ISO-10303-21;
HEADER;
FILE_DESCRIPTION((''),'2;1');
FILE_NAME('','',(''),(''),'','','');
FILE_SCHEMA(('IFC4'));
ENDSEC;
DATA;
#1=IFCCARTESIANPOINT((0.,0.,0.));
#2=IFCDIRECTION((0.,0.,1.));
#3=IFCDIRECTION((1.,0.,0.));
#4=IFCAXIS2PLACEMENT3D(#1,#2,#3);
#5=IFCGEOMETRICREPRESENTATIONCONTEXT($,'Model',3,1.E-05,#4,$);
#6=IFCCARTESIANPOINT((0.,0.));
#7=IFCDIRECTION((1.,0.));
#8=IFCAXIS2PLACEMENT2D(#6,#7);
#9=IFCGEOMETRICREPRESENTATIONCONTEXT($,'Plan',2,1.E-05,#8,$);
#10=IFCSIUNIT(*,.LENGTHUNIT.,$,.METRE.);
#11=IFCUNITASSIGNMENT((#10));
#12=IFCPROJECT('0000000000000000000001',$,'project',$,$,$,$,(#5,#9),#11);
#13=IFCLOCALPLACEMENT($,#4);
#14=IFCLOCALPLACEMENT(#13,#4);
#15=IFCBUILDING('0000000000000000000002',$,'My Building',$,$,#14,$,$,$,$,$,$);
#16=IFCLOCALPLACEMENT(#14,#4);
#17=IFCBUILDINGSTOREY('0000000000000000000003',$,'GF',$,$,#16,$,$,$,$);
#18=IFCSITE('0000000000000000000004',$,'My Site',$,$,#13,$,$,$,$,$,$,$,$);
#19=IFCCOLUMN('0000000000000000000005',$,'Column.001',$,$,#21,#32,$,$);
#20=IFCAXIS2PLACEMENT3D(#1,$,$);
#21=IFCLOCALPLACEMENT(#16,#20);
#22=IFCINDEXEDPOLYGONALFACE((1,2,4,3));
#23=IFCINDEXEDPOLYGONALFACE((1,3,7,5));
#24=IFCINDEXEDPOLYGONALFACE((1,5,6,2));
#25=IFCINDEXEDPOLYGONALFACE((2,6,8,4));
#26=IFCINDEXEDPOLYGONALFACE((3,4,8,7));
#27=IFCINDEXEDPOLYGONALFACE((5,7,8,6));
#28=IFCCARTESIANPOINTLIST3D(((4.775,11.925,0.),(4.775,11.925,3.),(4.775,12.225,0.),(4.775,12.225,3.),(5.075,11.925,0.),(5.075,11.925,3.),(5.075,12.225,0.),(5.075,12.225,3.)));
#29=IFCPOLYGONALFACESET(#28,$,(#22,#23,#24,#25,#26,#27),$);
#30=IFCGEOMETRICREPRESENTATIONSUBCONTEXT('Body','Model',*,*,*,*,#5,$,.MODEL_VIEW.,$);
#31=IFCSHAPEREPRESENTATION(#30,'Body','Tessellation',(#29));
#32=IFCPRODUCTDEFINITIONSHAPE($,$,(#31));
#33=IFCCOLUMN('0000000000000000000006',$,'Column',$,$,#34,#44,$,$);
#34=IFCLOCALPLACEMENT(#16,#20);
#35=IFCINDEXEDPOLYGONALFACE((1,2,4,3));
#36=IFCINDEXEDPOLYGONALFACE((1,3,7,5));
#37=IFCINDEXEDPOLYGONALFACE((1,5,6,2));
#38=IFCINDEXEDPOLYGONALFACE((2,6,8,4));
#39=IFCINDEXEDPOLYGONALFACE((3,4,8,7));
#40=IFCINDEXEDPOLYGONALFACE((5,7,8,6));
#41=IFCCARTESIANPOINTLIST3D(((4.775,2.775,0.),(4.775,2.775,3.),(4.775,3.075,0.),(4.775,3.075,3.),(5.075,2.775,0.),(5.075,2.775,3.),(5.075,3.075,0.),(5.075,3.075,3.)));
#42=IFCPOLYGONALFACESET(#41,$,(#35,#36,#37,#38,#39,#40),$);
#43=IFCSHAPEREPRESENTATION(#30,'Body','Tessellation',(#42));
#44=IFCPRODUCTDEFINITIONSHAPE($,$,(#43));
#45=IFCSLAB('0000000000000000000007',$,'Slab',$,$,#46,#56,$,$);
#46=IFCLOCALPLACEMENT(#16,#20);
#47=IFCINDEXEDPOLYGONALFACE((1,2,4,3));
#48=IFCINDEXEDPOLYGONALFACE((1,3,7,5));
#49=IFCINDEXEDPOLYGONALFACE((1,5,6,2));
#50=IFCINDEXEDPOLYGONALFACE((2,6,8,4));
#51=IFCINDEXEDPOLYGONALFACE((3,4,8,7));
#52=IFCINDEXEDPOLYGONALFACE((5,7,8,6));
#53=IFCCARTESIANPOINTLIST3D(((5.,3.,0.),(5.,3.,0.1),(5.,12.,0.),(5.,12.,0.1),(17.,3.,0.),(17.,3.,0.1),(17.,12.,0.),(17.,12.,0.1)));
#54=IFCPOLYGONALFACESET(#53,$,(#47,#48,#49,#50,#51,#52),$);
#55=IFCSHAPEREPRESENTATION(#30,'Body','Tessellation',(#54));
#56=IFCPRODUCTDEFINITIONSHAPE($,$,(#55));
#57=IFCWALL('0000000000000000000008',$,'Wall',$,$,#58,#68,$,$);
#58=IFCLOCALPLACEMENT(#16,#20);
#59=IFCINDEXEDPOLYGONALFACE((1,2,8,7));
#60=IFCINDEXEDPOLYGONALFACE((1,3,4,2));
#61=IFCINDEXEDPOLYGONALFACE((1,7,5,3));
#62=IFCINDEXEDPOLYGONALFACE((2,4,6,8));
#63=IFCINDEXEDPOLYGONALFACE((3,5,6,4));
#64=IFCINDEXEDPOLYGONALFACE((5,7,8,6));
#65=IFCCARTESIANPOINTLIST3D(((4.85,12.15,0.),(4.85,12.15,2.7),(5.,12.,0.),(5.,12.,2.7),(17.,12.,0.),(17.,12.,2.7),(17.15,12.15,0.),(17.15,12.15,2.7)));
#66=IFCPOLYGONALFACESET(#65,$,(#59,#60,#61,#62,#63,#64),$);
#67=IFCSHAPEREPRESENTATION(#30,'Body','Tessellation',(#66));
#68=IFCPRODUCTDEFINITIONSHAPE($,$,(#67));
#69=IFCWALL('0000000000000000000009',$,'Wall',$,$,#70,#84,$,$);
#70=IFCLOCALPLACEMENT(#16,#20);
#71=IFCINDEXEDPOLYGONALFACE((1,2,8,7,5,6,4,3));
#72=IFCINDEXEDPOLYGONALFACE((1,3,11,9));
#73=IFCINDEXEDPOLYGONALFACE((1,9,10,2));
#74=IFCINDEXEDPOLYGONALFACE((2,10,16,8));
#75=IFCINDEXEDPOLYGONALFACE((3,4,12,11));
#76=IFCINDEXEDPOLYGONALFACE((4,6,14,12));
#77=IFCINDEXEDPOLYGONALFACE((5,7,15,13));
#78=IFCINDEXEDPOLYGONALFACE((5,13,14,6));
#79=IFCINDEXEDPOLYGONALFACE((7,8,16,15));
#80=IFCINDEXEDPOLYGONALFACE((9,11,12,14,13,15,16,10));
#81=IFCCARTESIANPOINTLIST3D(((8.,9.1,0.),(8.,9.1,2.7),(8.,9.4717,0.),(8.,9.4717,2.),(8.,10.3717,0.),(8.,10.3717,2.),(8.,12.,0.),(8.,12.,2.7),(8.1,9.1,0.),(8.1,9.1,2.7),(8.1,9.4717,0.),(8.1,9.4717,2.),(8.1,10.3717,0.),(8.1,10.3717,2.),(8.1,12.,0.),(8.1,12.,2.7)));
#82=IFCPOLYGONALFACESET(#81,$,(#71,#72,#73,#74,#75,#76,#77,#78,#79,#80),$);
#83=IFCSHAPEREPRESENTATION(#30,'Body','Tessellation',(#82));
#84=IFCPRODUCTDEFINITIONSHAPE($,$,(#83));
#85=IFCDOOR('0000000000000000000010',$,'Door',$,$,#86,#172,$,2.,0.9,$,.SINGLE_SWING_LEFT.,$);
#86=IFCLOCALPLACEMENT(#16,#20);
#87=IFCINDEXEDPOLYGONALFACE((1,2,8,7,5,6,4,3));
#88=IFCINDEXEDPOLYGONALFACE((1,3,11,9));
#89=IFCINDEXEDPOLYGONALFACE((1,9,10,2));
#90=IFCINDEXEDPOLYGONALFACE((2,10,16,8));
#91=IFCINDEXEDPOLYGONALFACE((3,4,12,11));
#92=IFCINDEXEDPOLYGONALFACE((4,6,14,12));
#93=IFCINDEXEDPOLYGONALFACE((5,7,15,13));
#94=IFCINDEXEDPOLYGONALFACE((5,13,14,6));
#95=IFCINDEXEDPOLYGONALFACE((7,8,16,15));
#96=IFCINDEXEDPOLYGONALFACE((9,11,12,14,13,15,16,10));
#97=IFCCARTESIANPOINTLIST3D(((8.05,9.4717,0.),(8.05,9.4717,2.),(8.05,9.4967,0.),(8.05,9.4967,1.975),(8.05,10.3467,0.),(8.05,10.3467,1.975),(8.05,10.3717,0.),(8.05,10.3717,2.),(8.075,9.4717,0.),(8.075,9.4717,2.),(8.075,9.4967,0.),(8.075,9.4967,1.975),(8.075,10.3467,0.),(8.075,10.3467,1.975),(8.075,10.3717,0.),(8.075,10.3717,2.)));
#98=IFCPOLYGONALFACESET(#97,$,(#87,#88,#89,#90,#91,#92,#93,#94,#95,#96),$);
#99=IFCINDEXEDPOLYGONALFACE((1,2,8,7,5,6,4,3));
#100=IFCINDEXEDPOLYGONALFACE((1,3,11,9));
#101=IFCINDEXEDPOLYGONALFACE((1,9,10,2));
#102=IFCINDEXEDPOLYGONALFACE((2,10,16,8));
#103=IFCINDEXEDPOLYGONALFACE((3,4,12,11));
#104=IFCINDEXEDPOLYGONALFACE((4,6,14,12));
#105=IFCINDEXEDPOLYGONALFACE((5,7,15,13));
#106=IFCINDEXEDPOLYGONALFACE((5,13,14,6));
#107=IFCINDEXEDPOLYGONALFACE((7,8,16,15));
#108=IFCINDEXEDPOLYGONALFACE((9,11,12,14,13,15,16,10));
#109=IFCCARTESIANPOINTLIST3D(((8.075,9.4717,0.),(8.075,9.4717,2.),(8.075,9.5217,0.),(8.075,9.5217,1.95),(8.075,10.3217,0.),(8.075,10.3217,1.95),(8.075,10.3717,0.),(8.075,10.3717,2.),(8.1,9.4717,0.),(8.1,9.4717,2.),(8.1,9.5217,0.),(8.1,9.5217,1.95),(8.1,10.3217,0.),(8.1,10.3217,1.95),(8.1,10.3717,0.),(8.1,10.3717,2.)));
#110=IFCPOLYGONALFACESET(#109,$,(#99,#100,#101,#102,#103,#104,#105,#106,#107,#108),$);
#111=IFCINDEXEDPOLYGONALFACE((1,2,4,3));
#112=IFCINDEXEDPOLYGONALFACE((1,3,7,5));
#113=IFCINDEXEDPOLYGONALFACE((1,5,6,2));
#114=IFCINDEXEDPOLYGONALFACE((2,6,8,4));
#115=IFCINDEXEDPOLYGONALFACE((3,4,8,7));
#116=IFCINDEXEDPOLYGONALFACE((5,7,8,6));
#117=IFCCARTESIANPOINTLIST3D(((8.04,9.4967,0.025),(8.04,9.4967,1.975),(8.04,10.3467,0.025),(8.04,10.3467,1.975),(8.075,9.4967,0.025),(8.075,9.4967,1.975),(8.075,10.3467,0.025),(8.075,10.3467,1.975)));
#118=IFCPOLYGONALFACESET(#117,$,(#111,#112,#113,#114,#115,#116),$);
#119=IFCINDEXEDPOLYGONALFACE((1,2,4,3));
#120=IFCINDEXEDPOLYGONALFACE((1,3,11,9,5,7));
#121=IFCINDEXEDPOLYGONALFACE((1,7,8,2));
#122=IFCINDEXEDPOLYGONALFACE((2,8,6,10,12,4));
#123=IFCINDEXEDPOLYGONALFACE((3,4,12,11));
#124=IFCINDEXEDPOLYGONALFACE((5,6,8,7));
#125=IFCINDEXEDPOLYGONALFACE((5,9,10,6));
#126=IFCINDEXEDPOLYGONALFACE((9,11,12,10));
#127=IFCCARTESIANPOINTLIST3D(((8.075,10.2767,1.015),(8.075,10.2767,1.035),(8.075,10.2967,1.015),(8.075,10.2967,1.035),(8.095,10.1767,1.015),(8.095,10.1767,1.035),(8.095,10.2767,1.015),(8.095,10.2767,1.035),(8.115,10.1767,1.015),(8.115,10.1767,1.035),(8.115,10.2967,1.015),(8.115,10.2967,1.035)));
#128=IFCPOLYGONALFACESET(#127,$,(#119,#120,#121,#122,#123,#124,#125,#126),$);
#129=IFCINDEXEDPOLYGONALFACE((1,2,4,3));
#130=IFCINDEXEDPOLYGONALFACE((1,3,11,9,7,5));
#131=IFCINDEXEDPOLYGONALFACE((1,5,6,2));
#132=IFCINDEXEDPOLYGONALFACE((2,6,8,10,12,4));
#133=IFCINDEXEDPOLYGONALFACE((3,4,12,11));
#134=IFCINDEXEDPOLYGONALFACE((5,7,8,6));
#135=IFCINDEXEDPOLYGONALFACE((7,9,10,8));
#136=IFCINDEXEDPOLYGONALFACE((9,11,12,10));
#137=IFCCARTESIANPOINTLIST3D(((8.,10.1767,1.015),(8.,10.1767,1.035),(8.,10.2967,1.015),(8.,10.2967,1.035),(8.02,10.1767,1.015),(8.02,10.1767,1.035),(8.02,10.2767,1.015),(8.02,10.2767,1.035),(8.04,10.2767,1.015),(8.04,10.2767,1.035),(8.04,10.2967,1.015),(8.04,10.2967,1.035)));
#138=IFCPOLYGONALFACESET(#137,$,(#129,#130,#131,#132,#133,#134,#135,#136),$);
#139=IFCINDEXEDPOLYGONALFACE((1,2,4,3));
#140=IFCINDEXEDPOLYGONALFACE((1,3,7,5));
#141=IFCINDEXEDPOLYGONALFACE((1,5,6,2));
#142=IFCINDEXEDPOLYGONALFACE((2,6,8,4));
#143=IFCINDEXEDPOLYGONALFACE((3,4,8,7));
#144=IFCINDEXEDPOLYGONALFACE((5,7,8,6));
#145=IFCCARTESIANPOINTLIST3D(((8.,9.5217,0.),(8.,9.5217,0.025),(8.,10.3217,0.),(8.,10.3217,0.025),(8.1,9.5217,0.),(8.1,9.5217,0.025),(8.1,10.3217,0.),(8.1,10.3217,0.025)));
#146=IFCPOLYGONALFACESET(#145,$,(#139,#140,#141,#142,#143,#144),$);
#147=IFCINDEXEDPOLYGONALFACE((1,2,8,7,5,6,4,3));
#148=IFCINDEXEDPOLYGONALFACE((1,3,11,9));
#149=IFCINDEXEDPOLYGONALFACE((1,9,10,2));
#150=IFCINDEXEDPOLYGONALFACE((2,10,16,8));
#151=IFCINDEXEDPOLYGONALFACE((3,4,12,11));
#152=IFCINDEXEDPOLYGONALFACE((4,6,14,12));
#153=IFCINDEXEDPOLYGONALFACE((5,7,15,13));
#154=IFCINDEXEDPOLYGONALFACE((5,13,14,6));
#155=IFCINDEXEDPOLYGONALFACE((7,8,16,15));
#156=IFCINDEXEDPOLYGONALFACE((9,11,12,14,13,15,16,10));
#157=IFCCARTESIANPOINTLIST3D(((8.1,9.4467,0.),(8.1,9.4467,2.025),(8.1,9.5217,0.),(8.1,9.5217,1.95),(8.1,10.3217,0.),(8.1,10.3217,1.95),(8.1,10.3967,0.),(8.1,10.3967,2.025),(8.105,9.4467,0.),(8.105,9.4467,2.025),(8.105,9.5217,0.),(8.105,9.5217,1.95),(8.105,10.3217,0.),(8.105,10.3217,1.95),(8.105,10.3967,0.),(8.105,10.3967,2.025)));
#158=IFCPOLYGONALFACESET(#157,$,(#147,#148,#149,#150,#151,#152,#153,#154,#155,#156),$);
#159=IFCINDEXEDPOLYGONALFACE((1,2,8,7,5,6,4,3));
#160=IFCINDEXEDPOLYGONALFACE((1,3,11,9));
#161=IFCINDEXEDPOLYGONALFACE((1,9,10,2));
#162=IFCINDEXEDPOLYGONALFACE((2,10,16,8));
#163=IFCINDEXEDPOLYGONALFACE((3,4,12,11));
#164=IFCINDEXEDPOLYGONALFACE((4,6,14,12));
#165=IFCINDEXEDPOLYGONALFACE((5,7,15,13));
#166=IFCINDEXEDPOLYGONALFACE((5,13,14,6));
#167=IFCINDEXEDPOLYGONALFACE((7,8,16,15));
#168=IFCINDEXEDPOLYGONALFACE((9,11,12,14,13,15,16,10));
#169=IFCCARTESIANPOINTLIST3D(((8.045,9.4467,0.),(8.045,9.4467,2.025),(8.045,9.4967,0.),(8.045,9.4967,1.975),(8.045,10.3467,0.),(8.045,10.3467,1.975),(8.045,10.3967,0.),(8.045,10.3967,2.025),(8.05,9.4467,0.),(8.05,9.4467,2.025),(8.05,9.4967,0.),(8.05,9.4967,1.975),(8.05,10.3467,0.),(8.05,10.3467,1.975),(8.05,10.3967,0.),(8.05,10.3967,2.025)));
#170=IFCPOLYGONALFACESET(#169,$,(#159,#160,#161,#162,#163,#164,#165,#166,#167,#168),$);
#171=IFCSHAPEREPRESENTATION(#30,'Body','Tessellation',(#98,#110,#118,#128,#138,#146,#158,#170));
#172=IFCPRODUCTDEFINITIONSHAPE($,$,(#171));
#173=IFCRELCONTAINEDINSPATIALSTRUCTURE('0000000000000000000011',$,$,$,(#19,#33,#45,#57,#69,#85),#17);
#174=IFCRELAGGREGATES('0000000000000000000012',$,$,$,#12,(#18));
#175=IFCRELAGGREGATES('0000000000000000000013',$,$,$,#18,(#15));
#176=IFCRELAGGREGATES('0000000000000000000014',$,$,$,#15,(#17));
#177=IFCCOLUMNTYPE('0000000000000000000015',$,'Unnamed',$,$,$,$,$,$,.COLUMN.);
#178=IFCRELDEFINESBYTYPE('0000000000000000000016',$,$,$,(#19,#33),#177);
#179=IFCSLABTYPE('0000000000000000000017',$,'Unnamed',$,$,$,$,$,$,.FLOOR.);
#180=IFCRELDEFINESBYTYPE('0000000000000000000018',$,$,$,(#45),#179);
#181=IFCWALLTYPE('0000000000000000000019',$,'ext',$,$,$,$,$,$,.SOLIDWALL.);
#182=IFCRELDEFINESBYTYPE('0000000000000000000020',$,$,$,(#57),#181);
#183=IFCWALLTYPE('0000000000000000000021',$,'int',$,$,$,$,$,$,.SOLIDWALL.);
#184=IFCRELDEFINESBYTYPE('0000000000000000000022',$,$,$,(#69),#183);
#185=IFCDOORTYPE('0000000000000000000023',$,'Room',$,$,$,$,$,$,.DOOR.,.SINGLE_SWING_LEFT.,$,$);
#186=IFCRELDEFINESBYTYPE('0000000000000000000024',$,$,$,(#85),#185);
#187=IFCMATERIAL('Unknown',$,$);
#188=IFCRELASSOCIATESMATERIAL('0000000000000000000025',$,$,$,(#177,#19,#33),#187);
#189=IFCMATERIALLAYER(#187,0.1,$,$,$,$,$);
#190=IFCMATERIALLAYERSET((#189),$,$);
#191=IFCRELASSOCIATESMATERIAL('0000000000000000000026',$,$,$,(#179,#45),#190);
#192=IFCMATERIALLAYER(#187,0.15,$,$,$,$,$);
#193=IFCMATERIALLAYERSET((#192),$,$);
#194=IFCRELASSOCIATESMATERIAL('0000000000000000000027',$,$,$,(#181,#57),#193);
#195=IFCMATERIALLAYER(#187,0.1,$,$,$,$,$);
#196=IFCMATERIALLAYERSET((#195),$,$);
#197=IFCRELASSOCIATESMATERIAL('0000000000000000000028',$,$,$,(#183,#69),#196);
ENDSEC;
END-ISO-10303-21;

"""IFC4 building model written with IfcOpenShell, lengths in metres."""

from ifc_helpers import new_model, entity, si_unit, frame, origin_with_axes, origin_2d_with_axis, place, context, subcontext, project, spatial, line, indexed_curve, rectangle, outline, extrude, shape, source, transform, mapped, material, layer, layer_set, layer_usage, material_profile, profile_set, profile_usage, type_object, type_shapes, element, fill, save


model = new_model("IFC4")

# Units and contexts
model_context = context("Model", 3, precision=1e-05, world=origin_with_axes())
plan_context = context("Plan", 2, precision=1e-05, world=origin_2d_with_axis())
body_context_1 = subcontext(model_context, "Body", "Model", "MODEL_VIEW")
body_context_2 = subcontext(plan_context, "Body", "Plan", "PLAN_VIEW")
ifc_project = project(units=[si_unit("LENGTHUNIT", "METRE")], contexts=[model_context, plan_context])

# Site, building, storey
site_placement = place(None, origin_with_axes())
site = spatial("IfcSite", under=ifc_project, at=site_placement, Name="My Site")
building_placement = place(site_placement, origin_with_axes())
building = spatial("IfcBuilding", under=site, at=building_placement, Name="My Building")
storey_placement = place(building_placement, origin_with_axes())
storey = spatial("IfcBuildingStorey", under=building, at=storey_placement, Name="GF")

# Columns
ifc_material = material(Name="Unknown")
ifc_material_profile = material_profile(ifc_material, rectangle(XDim=0.3, YDim=0.3))
ifc_profile_set = profile_set([ifc_material_profile])
ifc_profile_usage_1 = profile_usage(ifc_profile_set, cardinal=5)
column_type = type_object("IfcColumnType", Name="Unnamed", PredefinedType="COLUMN", material=ifc_profile_set)
column_1_placement = place(storey_placement, frame((4.925, 12.075, 0.0), z_axis=(0.0, 0.0, 1.0), x_axis=(1.0, 0.0, 0.0)))
element("IfcColumn", 1, at=column_1_placement, inside=storey, type_object=column_type, material=ifc_profile_usage_1, Name="Column.001", context=body_context_1, shape_type="SweptSolid", body=[
    extrude(rectangle(XDim=0.3, YDim=0.3), origin_with_axes(), (0.0, 0.0, 1.0), 3.0),
])
ifc_profile_usage_2 = profile_usage(ifc_profile_set, cardinal=5)
column_2_placement = place(storey_placement, frame((4.925, 2.925, 0.0), z_axis=(0.0, 0.0, 1.0), x_axis=(1.0, 0.0, 0.0)))
element("IfcColumn", 2, at=column_2_placement, inside=storey, type_object=column_type, material=ifc_profile_usage_2, Name="Column", context=body_context_1, shape_type="SweptSolid", body=[
    extrude(rectangle(XDim=0.3, YDim=0.3), origin_with_axes(), (0.0, 0.0, 1.0), 3.0),
])

# Slab
ifc_layer_1 = layer(ifc_material, 0.1)
ifc_layer_set_1 = layer_set([ifc_layer_1])
ifc_layer_usage_1 = layer_usage(ifc_layer_set_1, "AXIS3", "POSITIVE", -0.1)
slab_type = type_object("IfcSlabType", Name="Unnamed", PredefinedType="FLOOR", material=ifc_layer_set_1)
slab_placement = place(storey_placement, frame((5.0, 12.0, 0.1), z_axis=(0.0, 0.0, 1.0), x_axis=(1.0, 0.0, 0.0)))
element("IfcSlab", 3, at=slab_placement, inside=storey, type_object=slab_type, material=ifc_layer_usage_1, Name="Slab", context=body_context_1, shape_type="SweptSolid", body=[
    extrude(outline(indexed_curve([(0.0, 0.0), (12.0, 0.0), (12.0, -9.0), (0.0, -9.0), (0.0, 0.0)])), frame((0.0, 0.0, -0.1), z_axis=(0.0, 0.0, 1.0), x_axis=(1.0, 0.0, 0.0)), (0.0, 0.0, 1.0), 0.1),
])

# Shared definitions
ifc_layer_2 = layer(ifc_material, 0.15)
ifc_layer_set_2 = layer_set([ifc_layer_2])
wall_type_1 = type_object("IfcWallType", Name="ext", PredefinedType="SOLIDWALL", material=ifc_layer_set_2)

# Wall
ifc_layer_usage_2 = layer_usage(ifc_layer_set_2, "AXIS2", "POSITIVE", 0.0)
wall_1_placement = place(storey_placement, frame((5.0, 12.0, 0.0), z_axis=(0.0, 0.0, 1.0), x_axis=(1.0, 0.0, 0.0)))
element("IfcWall", 4, at=wall_1_placement, inside=storey, type_object=wall_type_1, material=ifc_layer_usage_2, Name="Wall", context=body_context_1, shape_type="SweptSolid", body=[
    extrude(outline(indexed_curve([(0.0, 0.0), (-0.15, 0.15), (12.15, 0.15), (12.0, 0.0)], segments=[line(1, 2, 3, 4, 1)])), origin_with_axes(), (0.0, 0.0, 1.0), 2.7),
])

# Wall, opening, door
ifc_layer_3 = layer(ifc_material, 0.1)
ifc_layer_set_3 = layer_set([ifc_layer_3])
ifc_layer_usage_3 = layer_usage(ifc_layer_set_3, "AXIS2", "POSITIVE", 0.0)
wall_type_2 = type_object("IfcWallType", Name="int", PredefinedType="SOLIDWALL", material=ifc_layer_set_3)
wall_2_placement = place(storey_placement, frame((8.0, 12.0, 0.0), z_axis=(0.0, 0.0, 1.0), x_axis=(0.0, -1.0, 0.0)))
wall_2 = element("IfcWall", 5, at=wall_2_placement, inside=storey, type_object=wall_type_2, material=ifc_layer_usage_3, Name="Wall", context=body_context_1, shape_type="SweptSolid", body=[
    extrude(outline(indexed_curve([(0.0, 0.0), (0.0, 0.1), (2.9, 0.1), (2.9, 0.0)], segments=[line(1, 2, 3, 4, 1)])), origin_with_axes(), (0.0, 0.0, 1.0), 2.7),
])
shared_shape_1 = source(origin_with_axes(), body_context_1, "Body", "SweptSolid", [
    extrude(outline(indexed_curve([(0.0, 0.0), (0.9, 0.0), (0.9, 2.0), (0.0, 2.0)], segments=[line(1, 2, 3, 4, 1)])), frame((0.0, -0.6, 0.0), z_axis=(0.0, -1.0, 0.0), x_axis=(1.0, 0.0, 0.0)), (0.0, 0.0, -1.0), 1.2),
])
opening_1_placement = place(wall_2_placement, frame((2.5283, 0.1, 0.0), z_axis=(0.0, 0.0, 1.0), x_axis=(-1.0, 0.0, 0.0)))
opening_1 = element("IfcOpeningElement", 6, at=opening_1_placement, cuts=wall_2, PredefinedType="OPENING", context=body_context_1, shape_type="MappedRepresentation", body=[
    mapped(shared_shape_1, transform((0.0, 0.0, 0.0), x_axis=(1.0, 0.0, 0.0), y_axis=(0.0, 1.0, 0.0), z_axis=(0.0, 0.0, 1.0), scale=1.0)),
])
door_type_1 = type_object("IfcDoorType", Name="Room", OperationType="SINGLE_SWING_LEFT", PredefinedType="DOOR")
shared_shape_2 = source(origin_with_axes(), body_context_1, "Body", "SweptSolid", [
    extrude(outline(indexed_curve([(0.0, 0.0), (0.0, 2.0), (0.9, 2.0), (0.9, 0.0), (0.875, 0.0), (0.875, 1.975), (0.025, 1.975), (0.025, 0.0)], segments=[line(1, 2, 3, 4, 5, 6, 7, 8, 1)])), frame((0.0, 0.025, 0.0), z_axis=(0.0, -1.0, 0.0), x_axis=(1.0, 0.0, 0.0)), (0.0, 0.0, -1.0), 0.025),
    extrude(outline(indexed_curve([(0.0, 0.0), (0.0, 2.0), (0.9, 2.0), (0.9, 0.0), (0.85, 0.0), (0.85, 1.95), (0.05, 1.95), (0.05, 0.0)], segments=[line(1, 2, 3, 4, 5, 6, 7, 8, 1)])), frame((0.0, 0.0, 0.0), z_axis=(0.0, -1.0, 0.0), x_axis=(1.0, 0.0, 0.0)), (0.0, 0.0, -1.0), 0.025),
    extrude(outline(indexed_curve([(0.0, 0.0), (0.85, 0.0), (0.85, 0.035), (0.0, 0.035)], segments=[line(1, 2, 3, 4, 1)])), frame((0.025, 0.025, 0.025), z_axis=(0.0, 0.0, 1.0), x_axis=(1.0, 0.0, 0.0)), (0.0, 0.0, 1.0), 1.95),
    extrude(outline(indexed_curve([(0.0, 0.0), (0.0, -0.04), (-0.12, -0.04), (-0.12, -0.02), (-0.02, -0.02), (-0.02, 0.0)], segments=[line(1, 2, 3, 4, 5, 6, 1)])), frame((0.825, 0.025, 1.015), z_axis=(0.0, 0.0, 1.0), x_axis=(1.0, 0.0, 0.0)), (0.0, 0.0, 1.0), 0.02),
    extrude(outline(indexed_curve([(0.0, 0.0), (0.0, 0.04), (-0.12, 0.04), (-0.12, 0.02), (-0.02, 0.02), (-0.02, 0.0)], segments=[line(1, 2, 3, 4, 5, 6, 1)])), frame((0.825, 0.06, 1.015), z_axis=(0.0, 0.0, 1.0), x_axis=(1.0, 0.0, 0.0)), (0.0, 0.0, 1.0), 0.02),
    extrude(outline(indexed_curve([(0.0, 0.0), (0.8, 0.0), (0.8, 0.1), (0.0, 0.1)], segments=[line(1, 2, 3, 4, 1)])), frame((0.05, 0.0, 0.0), z_axis=(0.0, 0.0, 1.0), x_axis=(1.0, 0.0, 0.0)), (0.0, 0.0, 1.0), 0.025),
    extrude(outline(indexed_curve([(0.0, 0.0), (0.0, 2.025), (0.95, 2.025), (0.95, 0.0), (0.875, 0.0), (0.875, 1.95), (0.075, 1.95), (0.075, 0.0)], segments=[line(1, 2, 3, 4, 5, 6, 7, 8, 1)])), frame((-0.025, -0.005, 0.0), z_axis=(0.0, -1.0, 0.0), x_axis=(1.0, 0.0, 0.0)), (0.0, 0.0, -1.0), 0.005),
    extrude(outline(indexed_curve([(0.0, 0.0), (0.0, 2.025), (0.95, 2.025), (0.95, 0.0), (0.9, 0.0), (0.9, 1.975), (0.05, 1.975), (0.05, 0.0)], segments=[line(1, 2, 3, 4, 5, 6, 7, 8, 1)])), frame((-0.025, 0.05, 0.0), z_axis=(0.0, -1.0, 0.0), x_axis=(1.0, 0.0, 0.0)), (0.0, 0.0, -1.0), 0.005),
])
shared_shape_3 = source(origin_with_axes(), body_context_2, "Body", "Curve2D", [
    entity("IfcIndexedPolyCurve", entity("IfcCartesianPointList2D", [[0.0, 0.0], [0.0, 0.05], [0.025, 0.05], [0.025, 0.025], [0.05, 0.025], [0.05, 0.0]]), [entity("IfcLineIndex", [1, 2, 3, 4, 5, 6, 1])]),
    entity("IfcIndexedPolyCurve", entity("IfcCartesianPointList2D", [[0.9, 0.0], [0.9, 0.05], [0.875, 0.05], [0.875, 0.025], [0.85, 0.025], [0.85, 0.0]]), [entity("IfcLineIndex", [1, 2, 3, 4, 5, 6, 1])]),
    entity("IfcTrimmedCurve", entity("IfcEllipse", entity("IfcAxis2Placement2D", entity("IfcCartesianPoint", [0.06, 0.05]), entity("IfcDirection", [1.0, 0.0])), 0.815, 0.85), [entity("IfcCartesianPoint", [0.875, 0.05])], [entity("IfcCartesianPoint", [0.06, 0.9])], True, "CARTESIAN"),
    entity("IfcIndexedPolyCurve", entity("IfcCartesianPointList2D", [[0.025, 0.05], [0.06, 0.05], [0.06, 0.9], [0.025, 0.9]]), [entity("IfcLineIndex", [1, 2, 3, 4, 1])]),
])
type_shapes(door_type_1, [shared_shape_2, shared_shape_3])
door_1_placement = place(opening_1_placement, frame((0.0, 0.0, 0.0), z_axis=(0.0, 0.0, 1.0), x_axis=(1.0, 0.0, 0.0)))
door_1 = element("IfcDoor", 7, at=door_1_placement, inside=storey, type_object=door_type_1, Name="Door", OperationType="SINGLE_SWING_LEFT", OverallHeight=2.0, OverallWidth=0.9, shapes=[
    shape(body_context_1, "Body", "MappedRepresentation", [mapped(shared_shape_2, transform((0.0, 0.0, 0.0), x_axis=(1.0, 0.0, 0.0), y_axis=(0.0, 1.0, 0.0), z_axis=(0.0, 0.0, 1.0), scale=1.0))]),
    shape(body_context_2, "Body", "MappedRepresentation", [mapped(shared_shape_3, transform((0.0, 0.0, 0.0), x_axis=(1.0, 0.0, 0.0), y_axis=(0.0, 1.0, 0.0), z_axis=(0.0, 0.0, 1.0), scale=1.0))]),
])
fill(opening_1, door_1)

save(model, "model.ifc")
